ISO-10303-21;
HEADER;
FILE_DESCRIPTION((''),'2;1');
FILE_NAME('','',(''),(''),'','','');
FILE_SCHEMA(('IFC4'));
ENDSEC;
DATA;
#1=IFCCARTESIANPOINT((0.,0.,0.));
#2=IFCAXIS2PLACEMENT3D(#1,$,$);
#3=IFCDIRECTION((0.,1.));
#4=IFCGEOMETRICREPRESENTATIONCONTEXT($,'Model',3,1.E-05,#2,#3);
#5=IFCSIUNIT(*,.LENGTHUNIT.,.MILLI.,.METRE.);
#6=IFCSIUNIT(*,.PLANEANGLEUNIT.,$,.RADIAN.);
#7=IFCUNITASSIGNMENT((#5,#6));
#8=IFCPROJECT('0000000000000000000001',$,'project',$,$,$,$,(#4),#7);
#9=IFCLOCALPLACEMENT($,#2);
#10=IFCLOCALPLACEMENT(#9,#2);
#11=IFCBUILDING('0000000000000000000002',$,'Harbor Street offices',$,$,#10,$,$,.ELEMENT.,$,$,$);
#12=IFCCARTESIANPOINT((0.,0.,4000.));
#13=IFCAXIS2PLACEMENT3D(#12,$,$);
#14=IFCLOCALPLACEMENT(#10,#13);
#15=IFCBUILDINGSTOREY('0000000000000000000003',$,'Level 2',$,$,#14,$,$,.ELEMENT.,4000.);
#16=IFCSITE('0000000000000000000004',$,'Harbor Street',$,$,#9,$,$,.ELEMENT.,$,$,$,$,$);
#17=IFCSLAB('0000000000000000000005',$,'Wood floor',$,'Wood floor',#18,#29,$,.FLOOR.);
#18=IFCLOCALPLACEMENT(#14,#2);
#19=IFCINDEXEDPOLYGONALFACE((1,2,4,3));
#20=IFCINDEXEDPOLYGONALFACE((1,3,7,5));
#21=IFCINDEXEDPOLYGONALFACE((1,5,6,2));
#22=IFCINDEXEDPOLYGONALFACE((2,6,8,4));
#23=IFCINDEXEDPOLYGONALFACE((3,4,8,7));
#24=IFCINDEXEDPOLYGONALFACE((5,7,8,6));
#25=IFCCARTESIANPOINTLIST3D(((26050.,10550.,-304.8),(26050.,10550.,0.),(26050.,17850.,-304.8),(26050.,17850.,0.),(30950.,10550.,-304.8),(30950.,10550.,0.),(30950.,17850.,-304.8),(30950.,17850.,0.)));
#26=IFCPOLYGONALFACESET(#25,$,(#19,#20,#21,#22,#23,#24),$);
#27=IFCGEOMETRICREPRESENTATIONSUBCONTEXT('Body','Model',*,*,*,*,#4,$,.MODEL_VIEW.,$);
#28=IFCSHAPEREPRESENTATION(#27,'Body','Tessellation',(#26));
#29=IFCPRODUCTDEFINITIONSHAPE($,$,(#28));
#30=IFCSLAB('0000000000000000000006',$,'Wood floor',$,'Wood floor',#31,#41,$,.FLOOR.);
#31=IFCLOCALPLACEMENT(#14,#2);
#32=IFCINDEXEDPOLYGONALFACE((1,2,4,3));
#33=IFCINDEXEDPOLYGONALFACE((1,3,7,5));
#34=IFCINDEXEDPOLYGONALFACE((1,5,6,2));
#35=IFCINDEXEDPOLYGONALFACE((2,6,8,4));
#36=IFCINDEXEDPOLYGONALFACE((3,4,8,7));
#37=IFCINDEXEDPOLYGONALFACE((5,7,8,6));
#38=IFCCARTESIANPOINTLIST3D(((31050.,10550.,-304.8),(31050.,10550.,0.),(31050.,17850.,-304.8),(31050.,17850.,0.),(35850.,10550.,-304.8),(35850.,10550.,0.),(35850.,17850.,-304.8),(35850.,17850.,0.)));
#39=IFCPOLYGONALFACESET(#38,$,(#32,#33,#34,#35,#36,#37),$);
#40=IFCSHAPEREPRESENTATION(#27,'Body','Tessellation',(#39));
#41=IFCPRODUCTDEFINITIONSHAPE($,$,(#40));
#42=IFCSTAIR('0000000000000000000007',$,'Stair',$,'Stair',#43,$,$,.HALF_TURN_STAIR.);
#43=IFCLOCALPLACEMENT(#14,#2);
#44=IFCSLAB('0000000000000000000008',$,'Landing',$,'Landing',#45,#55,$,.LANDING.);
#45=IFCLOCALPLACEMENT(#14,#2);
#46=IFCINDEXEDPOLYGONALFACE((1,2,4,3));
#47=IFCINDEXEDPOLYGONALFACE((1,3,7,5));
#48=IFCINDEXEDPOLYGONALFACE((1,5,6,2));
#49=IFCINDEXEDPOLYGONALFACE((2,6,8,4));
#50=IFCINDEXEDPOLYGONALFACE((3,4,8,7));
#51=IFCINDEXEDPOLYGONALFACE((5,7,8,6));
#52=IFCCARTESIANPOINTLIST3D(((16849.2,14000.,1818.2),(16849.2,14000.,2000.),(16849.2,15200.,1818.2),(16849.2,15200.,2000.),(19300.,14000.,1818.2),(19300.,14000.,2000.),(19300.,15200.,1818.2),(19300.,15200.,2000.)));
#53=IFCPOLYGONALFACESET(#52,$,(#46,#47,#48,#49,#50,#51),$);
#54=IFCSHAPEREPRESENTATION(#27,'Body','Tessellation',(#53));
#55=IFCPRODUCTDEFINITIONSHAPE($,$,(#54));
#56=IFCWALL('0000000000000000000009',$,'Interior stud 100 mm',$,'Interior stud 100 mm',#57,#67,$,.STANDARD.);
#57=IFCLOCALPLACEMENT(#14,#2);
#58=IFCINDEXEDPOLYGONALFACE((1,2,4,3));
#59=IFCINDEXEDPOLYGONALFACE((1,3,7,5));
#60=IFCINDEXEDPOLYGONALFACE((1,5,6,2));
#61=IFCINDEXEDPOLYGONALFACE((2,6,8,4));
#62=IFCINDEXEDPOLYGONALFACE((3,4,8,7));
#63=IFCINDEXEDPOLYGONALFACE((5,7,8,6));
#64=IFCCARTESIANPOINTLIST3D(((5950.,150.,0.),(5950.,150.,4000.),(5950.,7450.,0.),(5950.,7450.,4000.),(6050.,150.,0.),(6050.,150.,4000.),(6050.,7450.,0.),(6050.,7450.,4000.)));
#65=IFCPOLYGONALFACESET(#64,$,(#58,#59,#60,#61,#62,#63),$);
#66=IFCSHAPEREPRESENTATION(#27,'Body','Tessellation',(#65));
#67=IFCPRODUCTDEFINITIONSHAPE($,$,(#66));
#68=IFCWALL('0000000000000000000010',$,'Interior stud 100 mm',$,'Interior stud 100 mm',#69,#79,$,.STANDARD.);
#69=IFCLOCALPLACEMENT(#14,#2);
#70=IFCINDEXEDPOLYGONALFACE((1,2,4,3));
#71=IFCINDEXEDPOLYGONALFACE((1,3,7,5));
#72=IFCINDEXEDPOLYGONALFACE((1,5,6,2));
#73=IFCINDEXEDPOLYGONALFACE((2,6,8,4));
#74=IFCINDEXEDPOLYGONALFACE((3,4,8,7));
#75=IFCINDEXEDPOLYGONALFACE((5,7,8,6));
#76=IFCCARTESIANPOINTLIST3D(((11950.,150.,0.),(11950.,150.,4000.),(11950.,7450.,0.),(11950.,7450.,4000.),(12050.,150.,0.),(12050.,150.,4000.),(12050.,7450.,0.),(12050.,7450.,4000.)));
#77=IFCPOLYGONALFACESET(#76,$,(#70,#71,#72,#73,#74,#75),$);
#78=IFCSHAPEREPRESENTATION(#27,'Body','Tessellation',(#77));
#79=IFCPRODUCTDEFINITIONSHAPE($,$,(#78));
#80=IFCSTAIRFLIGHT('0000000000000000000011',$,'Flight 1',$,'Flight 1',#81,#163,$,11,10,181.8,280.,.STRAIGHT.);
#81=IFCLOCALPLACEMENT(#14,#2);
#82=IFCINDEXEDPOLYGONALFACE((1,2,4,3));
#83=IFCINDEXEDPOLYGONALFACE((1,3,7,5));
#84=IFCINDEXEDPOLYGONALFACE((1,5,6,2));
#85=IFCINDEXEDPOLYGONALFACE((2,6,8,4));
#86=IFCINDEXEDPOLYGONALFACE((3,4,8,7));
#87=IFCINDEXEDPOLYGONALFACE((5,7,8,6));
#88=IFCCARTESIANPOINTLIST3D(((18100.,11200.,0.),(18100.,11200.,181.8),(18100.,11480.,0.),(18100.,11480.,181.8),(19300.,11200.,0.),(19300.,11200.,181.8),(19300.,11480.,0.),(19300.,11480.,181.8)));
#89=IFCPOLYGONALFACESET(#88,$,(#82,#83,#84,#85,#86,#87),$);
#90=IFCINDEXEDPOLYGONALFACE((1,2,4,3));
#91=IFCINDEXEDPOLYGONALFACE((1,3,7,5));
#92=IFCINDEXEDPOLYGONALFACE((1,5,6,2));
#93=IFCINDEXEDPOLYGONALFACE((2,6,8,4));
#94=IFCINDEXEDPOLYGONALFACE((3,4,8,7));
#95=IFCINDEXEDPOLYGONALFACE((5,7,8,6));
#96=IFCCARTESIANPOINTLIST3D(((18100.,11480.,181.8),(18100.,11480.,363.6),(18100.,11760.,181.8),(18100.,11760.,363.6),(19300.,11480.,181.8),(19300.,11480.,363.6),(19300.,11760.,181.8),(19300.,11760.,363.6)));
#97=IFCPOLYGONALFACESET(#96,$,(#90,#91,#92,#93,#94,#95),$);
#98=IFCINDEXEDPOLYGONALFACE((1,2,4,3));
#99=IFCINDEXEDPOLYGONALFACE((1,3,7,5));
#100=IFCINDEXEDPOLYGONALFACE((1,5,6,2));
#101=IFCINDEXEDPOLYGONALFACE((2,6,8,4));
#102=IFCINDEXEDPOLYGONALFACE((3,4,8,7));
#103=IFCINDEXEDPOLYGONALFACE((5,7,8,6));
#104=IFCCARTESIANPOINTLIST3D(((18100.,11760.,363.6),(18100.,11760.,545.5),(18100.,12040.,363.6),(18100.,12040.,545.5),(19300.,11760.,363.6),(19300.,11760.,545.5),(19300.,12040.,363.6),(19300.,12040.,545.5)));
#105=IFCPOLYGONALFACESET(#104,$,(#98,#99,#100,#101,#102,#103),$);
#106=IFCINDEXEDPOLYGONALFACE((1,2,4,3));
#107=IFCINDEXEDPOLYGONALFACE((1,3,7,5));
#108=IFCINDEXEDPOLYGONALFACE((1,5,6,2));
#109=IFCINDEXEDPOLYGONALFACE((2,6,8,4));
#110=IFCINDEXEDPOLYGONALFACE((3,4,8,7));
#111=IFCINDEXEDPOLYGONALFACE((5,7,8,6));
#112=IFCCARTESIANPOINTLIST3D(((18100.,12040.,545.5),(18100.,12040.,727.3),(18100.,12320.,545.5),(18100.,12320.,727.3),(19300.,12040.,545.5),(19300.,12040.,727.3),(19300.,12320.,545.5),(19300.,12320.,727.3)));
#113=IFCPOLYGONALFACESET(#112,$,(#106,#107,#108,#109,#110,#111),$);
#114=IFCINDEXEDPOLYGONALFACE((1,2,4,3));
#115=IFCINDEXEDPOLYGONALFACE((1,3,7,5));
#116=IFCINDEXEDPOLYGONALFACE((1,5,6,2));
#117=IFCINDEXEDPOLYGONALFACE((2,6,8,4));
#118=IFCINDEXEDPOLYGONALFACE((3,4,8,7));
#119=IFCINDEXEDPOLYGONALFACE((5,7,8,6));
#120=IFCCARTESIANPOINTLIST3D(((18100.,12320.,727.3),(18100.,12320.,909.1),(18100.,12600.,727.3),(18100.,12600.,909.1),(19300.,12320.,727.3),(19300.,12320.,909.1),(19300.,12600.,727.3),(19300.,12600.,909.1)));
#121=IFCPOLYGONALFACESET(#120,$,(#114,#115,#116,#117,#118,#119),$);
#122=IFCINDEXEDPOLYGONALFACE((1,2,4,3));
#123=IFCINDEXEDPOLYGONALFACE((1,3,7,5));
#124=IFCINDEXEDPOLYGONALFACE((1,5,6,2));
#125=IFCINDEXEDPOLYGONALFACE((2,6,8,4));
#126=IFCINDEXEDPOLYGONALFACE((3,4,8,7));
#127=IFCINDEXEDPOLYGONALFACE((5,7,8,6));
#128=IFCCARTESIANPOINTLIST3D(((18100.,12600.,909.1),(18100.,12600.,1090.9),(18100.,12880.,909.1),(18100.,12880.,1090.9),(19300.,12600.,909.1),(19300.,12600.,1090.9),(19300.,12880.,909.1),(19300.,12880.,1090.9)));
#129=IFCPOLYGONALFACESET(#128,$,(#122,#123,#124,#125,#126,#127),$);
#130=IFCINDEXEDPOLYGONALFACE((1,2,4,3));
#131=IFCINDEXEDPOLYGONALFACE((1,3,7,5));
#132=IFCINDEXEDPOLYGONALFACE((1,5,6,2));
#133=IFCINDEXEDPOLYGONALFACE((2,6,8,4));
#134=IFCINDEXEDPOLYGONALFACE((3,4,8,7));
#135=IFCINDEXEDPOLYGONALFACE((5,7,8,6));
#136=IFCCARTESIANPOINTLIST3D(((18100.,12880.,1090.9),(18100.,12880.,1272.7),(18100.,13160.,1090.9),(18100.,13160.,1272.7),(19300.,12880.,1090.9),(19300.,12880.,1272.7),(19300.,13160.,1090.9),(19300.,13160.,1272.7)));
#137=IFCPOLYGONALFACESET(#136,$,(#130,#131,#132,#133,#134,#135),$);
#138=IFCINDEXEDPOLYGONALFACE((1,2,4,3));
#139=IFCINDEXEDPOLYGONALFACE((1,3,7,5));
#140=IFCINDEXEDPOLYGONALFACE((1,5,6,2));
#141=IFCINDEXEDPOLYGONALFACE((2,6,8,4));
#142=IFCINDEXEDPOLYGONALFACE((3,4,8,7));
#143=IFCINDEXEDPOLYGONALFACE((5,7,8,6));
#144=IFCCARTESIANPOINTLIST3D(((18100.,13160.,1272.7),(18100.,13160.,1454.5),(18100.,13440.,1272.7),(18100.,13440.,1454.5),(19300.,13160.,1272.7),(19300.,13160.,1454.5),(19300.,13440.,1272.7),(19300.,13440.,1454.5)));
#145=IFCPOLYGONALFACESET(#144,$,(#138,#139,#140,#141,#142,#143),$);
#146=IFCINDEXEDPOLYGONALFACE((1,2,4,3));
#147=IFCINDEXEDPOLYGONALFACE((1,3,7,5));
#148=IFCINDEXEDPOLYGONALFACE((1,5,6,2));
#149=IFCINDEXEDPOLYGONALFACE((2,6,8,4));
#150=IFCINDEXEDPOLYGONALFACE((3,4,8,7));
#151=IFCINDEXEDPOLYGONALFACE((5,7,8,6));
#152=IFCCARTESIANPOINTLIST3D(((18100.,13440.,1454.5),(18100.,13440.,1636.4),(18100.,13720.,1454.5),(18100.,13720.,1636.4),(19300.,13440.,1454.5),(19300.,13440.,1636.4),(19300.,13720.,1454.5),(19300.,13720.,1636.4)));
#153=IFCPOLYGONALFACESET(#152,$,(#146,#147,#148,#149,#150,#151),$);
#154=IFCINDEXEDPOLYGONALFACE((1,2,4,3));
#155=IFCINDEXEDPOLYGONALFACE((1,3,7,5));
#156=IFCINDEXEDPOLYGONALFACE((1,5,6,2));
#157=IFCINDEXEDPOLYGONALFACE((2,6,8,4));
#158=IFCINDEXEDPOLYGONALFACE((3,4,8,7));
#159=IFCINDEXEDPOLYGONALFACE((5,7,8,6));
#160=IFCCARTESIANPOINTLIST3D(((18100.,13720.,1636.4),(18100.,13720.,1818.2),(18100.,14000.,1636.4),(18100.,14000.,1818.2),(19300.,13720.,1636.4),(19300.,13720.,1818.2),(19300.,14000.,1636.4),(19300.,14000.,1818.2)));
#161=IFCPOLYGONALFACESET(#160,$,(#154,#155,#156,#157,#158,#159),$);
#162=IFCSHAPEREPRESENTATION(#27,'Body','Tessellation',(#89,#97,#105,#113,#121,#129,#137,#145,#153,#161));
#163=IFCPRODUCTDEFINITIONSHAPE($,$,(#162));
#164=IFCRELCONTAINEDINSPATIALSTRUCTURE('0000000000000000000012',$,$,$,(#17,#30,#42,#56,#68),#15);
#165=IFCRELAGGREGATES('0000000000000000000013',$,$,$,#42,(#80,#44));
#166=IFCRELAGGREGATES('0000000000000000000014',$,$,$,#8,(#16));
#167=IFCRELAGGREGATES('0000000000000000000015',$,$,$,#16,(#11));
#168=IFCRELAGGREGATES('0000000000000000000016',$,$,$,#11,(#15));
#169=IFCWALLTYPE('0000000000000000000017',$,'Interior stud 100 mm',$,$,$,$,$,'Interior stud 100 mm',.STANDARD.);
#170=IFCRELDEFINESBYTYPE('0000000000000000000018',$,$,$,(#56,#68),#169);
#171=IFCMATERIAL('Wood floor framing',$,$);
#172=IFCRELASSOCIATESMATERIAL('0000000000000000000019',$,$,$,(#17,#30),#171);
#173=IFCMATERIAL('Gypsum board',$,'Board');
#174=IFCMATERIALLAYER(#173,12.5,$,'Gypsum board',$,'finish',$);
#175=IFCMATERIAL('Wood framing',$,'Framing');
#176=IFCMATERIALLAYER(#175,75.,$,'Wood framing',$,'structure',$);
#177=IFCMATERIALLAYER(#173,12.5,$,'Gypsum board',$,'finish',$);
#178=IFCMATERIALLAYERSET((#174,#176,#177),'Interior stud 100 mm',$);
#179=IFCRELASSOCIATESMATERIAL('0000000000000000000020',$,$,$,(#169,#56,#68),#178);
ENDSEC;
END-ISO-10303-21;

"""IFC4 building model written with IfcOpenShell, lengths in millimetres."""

from ifc_helpers import new_model, si_unit, direction, frame, origin, origin_with_axes, place, context, subcontext, project, spatial, polyline, outline, extrude, material, layer, layer_set, layer_usage, type_object, element, aggregate, save


model = new_model("IFC4")

# Units and contexts
model_context = context("Model", 3, precision=1e-05, world=origin(), true_north=direction((0.0, 1.0)))
body_context = subcontext(model_context, "Body", "Model", "MODEL_VIEW")
ifc_project = project(units=[si_unit("LENGTHUNIT", "METRE", prefix="MILLI"), si_unit("PLANEANGLEUNIT", "RADIAN")], contexts=[model_context])

# Site, building, storey
site_placement = place(None, origin())
site = spatial("IfcSite", under=ifc_project, at=site_placement, Name="Harbor Street", CompositionType="ELEMENT")
building_placement = place(site_placement, origin())
building = spatial("IfcBuilding", under=site, at=building_placement, Name="Harbor Street offices", CompositionType="ELEMENT")
storey_placement = place(building_placement, frame((0.0, 0.0, 4000.0)))
storey = spatial("IfcBuildingStorey", under=building, at=storey_placement, Name="Level 2", CompositionType="ELEMENT", Elevation=4000.0)

# Slabs
ifc_material_1 = material(Name="Wood floor framing")
slab_1_placement = place(storey_placement, origin_with_axes())
element("IfcSlab", 1, at=slab_1_placement, inside=storey, material=ifc_material_1, Name="Wood floor", ObjectType="Wood floor", PredefinedType="FLOOR", context=body_context, shape_type="SweptSolid", body=[
    extrude(outline(polyline([(30950.0, 17850.0), (26050.0, 17850.0), (26050.0, 10550.0), (30950.0, 10550.0), (30950.0, 17850.0)])), frame((0.0, 0.0, -304.8)), (0.0, 0.0, 1.0), 304.8),
])
slab_2_placement = place(storey_placement, origin_with_axes())
element("IfcSlab", 2, at=slab_2_placement, inside=storey, material=ifc_material_1, Name="Wood floor", ObjectType="Wood floor", PredefinedType="FLOOR", context=body_context, shape_type="SweptSolid", body=[
    extrude(outline(polyline([(35850.0, 10550.0), (35850.0, 17850.0), (31050.0, 17850.0), (31050.0, 10550.0), (35850.0, 10550.0)])), frame((0.0, 0.0, -304.8)), (0.0, 0.0, 1.0), 304.8),
])

# Stair, slab
stair_placement = place(storey_placement, origin_with_axes())
stair = element("IfcStair", 3, at=stair_placement, inside=storey, Name="Stair", ObjectType="Stair", PredefinedType="HALF_TURN_STAIR")
slab_3_placement = place(storey_placement, origin_with_axes())
slab_3 = element("IfcSlab", 4, at=slab_3_placement, Name="Landing", ObjectType="Landing", PredefinedType="LANDING", context=body_context, shape_type="SweptSolid", body=[
    extrude(outline(polyline([(19300.0, 14000.0), (19300.0, 15200.0), (16849.2, 15200.0), (16849.2, 14000.0), (19300.0, 14000.0)])), frame((0.0, 0.0, 1818.2)), (0.0, 0.0, 1.0), 181.8),
])

# Walls
ifc_material_2 = material(Name="Gypsum board", Category="Board")
ifc_layer_1 = layer(ifc_material_2, 12.5, Name="Gypsum board", Category="finish")
ifc_material_3 = material(Name="Wood framing", Category="Framing")
ifc_layer_2 = layer(ifc_material_3, 75.0, Name="Wood framing", Category="structure")
ifc_layer_3 = layer(ifc_material_2, 12.5, Name="Gypsum board", Category="finish")
ifc_layer_set = layer_set([ifc_layer_1, ifc_layer_2, ifc_layer_3], Name="Interior stud 100 mm")
ifc_layer_usage_1 = layer_usage(ifc_layer_set, "AXIS2", "NEGATIVE", 50.0)
wall_type = type_object("IfcWallType", Name="Interior stud 100 mm", ElementType="Interior stud 100 mm", PredefinedType="STANDARD", material=ifc_layer_set)
wall_1_placement = place(storey_placement, frame((6000.0, 0.0, 0.0), z_axis=(0.0, 0.0, 1.0), x_axis=(0.0, 1.0, 0.0)))
element("IfcWall", 5, at=wall_1_placement, inside=storey, type_object=wall_type, material=ifc_layer_usage_1, Name="Interior stud 100 mm", ObjectType="Interior stud 100 mm", PredefinedType="STANDARD", context=body_context, shape_type="SweptSolid", body=[
    extrude(outline(polyline([(150.0, -50.0), (7450.0, -50.0), (7450.0, 50.0), (150.0, 50.0), (150.0, -50.0)])), origin(), (0.0, 0.0, 1.0), 4000.0),
])
ifc_layer_usage_2 = layer_usage(ifc_layer_set, "AXIS2", "NEGATIVE", 50.0)
wall_2_placement = place(storey_placement, frame((12000.0, 0.0, 0.0), z_axis=(0.0, 0.0, 1.0), x_axis=(0.0, 1.0, 0.0)))
element("IfcWall", 6, at=wall_2_placement, inside=storey, type_object=wall_type, material=ifc_layer_usage_2, Name="Interior stud 100 mm", ObjectType="Interior stud 100 mm", PredefinedType="STANDARD", context=body_context, shape_type="SweptSolid", body=[
    extrude(outline(polyline([(150.0, -50.0), (7450.0, -50.0), (7450.0, 50.0), (150.0, 50.0), (150.0, -50.0)])), origin(), (0.0, 0.0, 1.0), 4000.0),
])

# Stair flight
stair_flight_1_placement = place(storey_placement, origin_with_axes())
stair_flight_1 = element("IfcStairFlight", 7, at=stair_flight_1_placement, Name="Flight 1", ObjectType="Flight 1", NumberOfRisers=11, NumberOfTreads=10, PredefinedType="STRAIGHT", RiserHeight=181.8, TreadLength=280.0, context=body_context, shape_type="SweptSolid", body=[
    extrude(outline(polyline([(19300.0, 11200.0), (19300.0, 11480.0), (18100.0, 11480.0), (18100.0, 11200.0), (19300.0, 11200.0)])), origin(), (0.0, 0.0, 1.0), 181.8),
    extrude(outline(polyline([(19300.0, 11480.0), (19300.0, 11760.0), (18100.0, 11760.0), (18100.0, 11480.0), (19300.0, 11480.0)])), frame((0.0, 0.0, 181.8)), (0.0, 0.0, 1.0), 181.8),
    extrude(outline(polyline([(19300.0, 11760.0), (19300.0, 12040.0), (18100.0, 12040.0), (18100.0, 11760.0), (19300.0, 11760.0)])), frame((0.0, 0.0, 363.6)), (0.0, 0.0, 1.0), 181.8),
    extrude(outline(polyline([(19300.0, 12040.0), (19300.0, 12320.0), (18100.0, 12320.0), (18100.0, 12040.0), (19300.0, 12040.0)])), frame((0.0, 0.0, 545.5)), (0.0, 0.0, 1.0), 181.8),
    extrude(outline(polyline([(19300.0, 12320.0), (19300.0, 12600.0), (18100.0, 12600.0), (18100.0, 12320.0), (19300.0, 12320.0)])), frame((0.0, 0.0, 727.3)), (0.0, 0.0, 1.0), 181.8),
    extrude(outline(polyline([(19300.0, 12600.0), (19300.0, 12880.0), (18100.0, 12880.0), (18100.0, 12600.0), (19300.0, 12600.0)])), frame((0.0, 0.0, 909.1)), (0.0, 0.0, 1.0), 181.8),
    extrude(outline(polyline([(19300.0, 12880.0), (19300.0, 13160.0), (18100.0, 13160.0), (18100.0, 12880.0), (19300.0, 12880.0)])), frame((0.0, 0.0, 1090.9)), (0.0, 0.0, 1.0), 181.8),
    extrude(outline(polyline([(19300.0, 13160.0), (19300.0, 13440.0), (18100.0, 13440.0), (18100.0, 13160.0), (19300.0, 13160.0)])), frame((0.0, 0.0, 1272.7)), (0.0, 0.0, 1.0), 181.8),
    extrude(outline(polyline([(19300.0, 13440.0), (19300.0, 13720.0), (18100.0, 13720.0), (18100.0, 13440.0), (19300.0, 13440.0)])), frame((0.0, 0.0, 1454.5)), (0.0, 0.0, 1.0), 181.8),
    extrude(outline(polyline([(19300.0, 13720.0), (19300.0, 14000.0), (18100.0, 14000.0), (18100.0, 13720.0), (19300.0, 13720.0)])), frame((0.0, 0.0, 1636.4)), (0.0, 0.0, 1.0), 181.8),
])

aggregate(stair, [stair_flight_1, slab_3])

save(model, "model.ifc")
